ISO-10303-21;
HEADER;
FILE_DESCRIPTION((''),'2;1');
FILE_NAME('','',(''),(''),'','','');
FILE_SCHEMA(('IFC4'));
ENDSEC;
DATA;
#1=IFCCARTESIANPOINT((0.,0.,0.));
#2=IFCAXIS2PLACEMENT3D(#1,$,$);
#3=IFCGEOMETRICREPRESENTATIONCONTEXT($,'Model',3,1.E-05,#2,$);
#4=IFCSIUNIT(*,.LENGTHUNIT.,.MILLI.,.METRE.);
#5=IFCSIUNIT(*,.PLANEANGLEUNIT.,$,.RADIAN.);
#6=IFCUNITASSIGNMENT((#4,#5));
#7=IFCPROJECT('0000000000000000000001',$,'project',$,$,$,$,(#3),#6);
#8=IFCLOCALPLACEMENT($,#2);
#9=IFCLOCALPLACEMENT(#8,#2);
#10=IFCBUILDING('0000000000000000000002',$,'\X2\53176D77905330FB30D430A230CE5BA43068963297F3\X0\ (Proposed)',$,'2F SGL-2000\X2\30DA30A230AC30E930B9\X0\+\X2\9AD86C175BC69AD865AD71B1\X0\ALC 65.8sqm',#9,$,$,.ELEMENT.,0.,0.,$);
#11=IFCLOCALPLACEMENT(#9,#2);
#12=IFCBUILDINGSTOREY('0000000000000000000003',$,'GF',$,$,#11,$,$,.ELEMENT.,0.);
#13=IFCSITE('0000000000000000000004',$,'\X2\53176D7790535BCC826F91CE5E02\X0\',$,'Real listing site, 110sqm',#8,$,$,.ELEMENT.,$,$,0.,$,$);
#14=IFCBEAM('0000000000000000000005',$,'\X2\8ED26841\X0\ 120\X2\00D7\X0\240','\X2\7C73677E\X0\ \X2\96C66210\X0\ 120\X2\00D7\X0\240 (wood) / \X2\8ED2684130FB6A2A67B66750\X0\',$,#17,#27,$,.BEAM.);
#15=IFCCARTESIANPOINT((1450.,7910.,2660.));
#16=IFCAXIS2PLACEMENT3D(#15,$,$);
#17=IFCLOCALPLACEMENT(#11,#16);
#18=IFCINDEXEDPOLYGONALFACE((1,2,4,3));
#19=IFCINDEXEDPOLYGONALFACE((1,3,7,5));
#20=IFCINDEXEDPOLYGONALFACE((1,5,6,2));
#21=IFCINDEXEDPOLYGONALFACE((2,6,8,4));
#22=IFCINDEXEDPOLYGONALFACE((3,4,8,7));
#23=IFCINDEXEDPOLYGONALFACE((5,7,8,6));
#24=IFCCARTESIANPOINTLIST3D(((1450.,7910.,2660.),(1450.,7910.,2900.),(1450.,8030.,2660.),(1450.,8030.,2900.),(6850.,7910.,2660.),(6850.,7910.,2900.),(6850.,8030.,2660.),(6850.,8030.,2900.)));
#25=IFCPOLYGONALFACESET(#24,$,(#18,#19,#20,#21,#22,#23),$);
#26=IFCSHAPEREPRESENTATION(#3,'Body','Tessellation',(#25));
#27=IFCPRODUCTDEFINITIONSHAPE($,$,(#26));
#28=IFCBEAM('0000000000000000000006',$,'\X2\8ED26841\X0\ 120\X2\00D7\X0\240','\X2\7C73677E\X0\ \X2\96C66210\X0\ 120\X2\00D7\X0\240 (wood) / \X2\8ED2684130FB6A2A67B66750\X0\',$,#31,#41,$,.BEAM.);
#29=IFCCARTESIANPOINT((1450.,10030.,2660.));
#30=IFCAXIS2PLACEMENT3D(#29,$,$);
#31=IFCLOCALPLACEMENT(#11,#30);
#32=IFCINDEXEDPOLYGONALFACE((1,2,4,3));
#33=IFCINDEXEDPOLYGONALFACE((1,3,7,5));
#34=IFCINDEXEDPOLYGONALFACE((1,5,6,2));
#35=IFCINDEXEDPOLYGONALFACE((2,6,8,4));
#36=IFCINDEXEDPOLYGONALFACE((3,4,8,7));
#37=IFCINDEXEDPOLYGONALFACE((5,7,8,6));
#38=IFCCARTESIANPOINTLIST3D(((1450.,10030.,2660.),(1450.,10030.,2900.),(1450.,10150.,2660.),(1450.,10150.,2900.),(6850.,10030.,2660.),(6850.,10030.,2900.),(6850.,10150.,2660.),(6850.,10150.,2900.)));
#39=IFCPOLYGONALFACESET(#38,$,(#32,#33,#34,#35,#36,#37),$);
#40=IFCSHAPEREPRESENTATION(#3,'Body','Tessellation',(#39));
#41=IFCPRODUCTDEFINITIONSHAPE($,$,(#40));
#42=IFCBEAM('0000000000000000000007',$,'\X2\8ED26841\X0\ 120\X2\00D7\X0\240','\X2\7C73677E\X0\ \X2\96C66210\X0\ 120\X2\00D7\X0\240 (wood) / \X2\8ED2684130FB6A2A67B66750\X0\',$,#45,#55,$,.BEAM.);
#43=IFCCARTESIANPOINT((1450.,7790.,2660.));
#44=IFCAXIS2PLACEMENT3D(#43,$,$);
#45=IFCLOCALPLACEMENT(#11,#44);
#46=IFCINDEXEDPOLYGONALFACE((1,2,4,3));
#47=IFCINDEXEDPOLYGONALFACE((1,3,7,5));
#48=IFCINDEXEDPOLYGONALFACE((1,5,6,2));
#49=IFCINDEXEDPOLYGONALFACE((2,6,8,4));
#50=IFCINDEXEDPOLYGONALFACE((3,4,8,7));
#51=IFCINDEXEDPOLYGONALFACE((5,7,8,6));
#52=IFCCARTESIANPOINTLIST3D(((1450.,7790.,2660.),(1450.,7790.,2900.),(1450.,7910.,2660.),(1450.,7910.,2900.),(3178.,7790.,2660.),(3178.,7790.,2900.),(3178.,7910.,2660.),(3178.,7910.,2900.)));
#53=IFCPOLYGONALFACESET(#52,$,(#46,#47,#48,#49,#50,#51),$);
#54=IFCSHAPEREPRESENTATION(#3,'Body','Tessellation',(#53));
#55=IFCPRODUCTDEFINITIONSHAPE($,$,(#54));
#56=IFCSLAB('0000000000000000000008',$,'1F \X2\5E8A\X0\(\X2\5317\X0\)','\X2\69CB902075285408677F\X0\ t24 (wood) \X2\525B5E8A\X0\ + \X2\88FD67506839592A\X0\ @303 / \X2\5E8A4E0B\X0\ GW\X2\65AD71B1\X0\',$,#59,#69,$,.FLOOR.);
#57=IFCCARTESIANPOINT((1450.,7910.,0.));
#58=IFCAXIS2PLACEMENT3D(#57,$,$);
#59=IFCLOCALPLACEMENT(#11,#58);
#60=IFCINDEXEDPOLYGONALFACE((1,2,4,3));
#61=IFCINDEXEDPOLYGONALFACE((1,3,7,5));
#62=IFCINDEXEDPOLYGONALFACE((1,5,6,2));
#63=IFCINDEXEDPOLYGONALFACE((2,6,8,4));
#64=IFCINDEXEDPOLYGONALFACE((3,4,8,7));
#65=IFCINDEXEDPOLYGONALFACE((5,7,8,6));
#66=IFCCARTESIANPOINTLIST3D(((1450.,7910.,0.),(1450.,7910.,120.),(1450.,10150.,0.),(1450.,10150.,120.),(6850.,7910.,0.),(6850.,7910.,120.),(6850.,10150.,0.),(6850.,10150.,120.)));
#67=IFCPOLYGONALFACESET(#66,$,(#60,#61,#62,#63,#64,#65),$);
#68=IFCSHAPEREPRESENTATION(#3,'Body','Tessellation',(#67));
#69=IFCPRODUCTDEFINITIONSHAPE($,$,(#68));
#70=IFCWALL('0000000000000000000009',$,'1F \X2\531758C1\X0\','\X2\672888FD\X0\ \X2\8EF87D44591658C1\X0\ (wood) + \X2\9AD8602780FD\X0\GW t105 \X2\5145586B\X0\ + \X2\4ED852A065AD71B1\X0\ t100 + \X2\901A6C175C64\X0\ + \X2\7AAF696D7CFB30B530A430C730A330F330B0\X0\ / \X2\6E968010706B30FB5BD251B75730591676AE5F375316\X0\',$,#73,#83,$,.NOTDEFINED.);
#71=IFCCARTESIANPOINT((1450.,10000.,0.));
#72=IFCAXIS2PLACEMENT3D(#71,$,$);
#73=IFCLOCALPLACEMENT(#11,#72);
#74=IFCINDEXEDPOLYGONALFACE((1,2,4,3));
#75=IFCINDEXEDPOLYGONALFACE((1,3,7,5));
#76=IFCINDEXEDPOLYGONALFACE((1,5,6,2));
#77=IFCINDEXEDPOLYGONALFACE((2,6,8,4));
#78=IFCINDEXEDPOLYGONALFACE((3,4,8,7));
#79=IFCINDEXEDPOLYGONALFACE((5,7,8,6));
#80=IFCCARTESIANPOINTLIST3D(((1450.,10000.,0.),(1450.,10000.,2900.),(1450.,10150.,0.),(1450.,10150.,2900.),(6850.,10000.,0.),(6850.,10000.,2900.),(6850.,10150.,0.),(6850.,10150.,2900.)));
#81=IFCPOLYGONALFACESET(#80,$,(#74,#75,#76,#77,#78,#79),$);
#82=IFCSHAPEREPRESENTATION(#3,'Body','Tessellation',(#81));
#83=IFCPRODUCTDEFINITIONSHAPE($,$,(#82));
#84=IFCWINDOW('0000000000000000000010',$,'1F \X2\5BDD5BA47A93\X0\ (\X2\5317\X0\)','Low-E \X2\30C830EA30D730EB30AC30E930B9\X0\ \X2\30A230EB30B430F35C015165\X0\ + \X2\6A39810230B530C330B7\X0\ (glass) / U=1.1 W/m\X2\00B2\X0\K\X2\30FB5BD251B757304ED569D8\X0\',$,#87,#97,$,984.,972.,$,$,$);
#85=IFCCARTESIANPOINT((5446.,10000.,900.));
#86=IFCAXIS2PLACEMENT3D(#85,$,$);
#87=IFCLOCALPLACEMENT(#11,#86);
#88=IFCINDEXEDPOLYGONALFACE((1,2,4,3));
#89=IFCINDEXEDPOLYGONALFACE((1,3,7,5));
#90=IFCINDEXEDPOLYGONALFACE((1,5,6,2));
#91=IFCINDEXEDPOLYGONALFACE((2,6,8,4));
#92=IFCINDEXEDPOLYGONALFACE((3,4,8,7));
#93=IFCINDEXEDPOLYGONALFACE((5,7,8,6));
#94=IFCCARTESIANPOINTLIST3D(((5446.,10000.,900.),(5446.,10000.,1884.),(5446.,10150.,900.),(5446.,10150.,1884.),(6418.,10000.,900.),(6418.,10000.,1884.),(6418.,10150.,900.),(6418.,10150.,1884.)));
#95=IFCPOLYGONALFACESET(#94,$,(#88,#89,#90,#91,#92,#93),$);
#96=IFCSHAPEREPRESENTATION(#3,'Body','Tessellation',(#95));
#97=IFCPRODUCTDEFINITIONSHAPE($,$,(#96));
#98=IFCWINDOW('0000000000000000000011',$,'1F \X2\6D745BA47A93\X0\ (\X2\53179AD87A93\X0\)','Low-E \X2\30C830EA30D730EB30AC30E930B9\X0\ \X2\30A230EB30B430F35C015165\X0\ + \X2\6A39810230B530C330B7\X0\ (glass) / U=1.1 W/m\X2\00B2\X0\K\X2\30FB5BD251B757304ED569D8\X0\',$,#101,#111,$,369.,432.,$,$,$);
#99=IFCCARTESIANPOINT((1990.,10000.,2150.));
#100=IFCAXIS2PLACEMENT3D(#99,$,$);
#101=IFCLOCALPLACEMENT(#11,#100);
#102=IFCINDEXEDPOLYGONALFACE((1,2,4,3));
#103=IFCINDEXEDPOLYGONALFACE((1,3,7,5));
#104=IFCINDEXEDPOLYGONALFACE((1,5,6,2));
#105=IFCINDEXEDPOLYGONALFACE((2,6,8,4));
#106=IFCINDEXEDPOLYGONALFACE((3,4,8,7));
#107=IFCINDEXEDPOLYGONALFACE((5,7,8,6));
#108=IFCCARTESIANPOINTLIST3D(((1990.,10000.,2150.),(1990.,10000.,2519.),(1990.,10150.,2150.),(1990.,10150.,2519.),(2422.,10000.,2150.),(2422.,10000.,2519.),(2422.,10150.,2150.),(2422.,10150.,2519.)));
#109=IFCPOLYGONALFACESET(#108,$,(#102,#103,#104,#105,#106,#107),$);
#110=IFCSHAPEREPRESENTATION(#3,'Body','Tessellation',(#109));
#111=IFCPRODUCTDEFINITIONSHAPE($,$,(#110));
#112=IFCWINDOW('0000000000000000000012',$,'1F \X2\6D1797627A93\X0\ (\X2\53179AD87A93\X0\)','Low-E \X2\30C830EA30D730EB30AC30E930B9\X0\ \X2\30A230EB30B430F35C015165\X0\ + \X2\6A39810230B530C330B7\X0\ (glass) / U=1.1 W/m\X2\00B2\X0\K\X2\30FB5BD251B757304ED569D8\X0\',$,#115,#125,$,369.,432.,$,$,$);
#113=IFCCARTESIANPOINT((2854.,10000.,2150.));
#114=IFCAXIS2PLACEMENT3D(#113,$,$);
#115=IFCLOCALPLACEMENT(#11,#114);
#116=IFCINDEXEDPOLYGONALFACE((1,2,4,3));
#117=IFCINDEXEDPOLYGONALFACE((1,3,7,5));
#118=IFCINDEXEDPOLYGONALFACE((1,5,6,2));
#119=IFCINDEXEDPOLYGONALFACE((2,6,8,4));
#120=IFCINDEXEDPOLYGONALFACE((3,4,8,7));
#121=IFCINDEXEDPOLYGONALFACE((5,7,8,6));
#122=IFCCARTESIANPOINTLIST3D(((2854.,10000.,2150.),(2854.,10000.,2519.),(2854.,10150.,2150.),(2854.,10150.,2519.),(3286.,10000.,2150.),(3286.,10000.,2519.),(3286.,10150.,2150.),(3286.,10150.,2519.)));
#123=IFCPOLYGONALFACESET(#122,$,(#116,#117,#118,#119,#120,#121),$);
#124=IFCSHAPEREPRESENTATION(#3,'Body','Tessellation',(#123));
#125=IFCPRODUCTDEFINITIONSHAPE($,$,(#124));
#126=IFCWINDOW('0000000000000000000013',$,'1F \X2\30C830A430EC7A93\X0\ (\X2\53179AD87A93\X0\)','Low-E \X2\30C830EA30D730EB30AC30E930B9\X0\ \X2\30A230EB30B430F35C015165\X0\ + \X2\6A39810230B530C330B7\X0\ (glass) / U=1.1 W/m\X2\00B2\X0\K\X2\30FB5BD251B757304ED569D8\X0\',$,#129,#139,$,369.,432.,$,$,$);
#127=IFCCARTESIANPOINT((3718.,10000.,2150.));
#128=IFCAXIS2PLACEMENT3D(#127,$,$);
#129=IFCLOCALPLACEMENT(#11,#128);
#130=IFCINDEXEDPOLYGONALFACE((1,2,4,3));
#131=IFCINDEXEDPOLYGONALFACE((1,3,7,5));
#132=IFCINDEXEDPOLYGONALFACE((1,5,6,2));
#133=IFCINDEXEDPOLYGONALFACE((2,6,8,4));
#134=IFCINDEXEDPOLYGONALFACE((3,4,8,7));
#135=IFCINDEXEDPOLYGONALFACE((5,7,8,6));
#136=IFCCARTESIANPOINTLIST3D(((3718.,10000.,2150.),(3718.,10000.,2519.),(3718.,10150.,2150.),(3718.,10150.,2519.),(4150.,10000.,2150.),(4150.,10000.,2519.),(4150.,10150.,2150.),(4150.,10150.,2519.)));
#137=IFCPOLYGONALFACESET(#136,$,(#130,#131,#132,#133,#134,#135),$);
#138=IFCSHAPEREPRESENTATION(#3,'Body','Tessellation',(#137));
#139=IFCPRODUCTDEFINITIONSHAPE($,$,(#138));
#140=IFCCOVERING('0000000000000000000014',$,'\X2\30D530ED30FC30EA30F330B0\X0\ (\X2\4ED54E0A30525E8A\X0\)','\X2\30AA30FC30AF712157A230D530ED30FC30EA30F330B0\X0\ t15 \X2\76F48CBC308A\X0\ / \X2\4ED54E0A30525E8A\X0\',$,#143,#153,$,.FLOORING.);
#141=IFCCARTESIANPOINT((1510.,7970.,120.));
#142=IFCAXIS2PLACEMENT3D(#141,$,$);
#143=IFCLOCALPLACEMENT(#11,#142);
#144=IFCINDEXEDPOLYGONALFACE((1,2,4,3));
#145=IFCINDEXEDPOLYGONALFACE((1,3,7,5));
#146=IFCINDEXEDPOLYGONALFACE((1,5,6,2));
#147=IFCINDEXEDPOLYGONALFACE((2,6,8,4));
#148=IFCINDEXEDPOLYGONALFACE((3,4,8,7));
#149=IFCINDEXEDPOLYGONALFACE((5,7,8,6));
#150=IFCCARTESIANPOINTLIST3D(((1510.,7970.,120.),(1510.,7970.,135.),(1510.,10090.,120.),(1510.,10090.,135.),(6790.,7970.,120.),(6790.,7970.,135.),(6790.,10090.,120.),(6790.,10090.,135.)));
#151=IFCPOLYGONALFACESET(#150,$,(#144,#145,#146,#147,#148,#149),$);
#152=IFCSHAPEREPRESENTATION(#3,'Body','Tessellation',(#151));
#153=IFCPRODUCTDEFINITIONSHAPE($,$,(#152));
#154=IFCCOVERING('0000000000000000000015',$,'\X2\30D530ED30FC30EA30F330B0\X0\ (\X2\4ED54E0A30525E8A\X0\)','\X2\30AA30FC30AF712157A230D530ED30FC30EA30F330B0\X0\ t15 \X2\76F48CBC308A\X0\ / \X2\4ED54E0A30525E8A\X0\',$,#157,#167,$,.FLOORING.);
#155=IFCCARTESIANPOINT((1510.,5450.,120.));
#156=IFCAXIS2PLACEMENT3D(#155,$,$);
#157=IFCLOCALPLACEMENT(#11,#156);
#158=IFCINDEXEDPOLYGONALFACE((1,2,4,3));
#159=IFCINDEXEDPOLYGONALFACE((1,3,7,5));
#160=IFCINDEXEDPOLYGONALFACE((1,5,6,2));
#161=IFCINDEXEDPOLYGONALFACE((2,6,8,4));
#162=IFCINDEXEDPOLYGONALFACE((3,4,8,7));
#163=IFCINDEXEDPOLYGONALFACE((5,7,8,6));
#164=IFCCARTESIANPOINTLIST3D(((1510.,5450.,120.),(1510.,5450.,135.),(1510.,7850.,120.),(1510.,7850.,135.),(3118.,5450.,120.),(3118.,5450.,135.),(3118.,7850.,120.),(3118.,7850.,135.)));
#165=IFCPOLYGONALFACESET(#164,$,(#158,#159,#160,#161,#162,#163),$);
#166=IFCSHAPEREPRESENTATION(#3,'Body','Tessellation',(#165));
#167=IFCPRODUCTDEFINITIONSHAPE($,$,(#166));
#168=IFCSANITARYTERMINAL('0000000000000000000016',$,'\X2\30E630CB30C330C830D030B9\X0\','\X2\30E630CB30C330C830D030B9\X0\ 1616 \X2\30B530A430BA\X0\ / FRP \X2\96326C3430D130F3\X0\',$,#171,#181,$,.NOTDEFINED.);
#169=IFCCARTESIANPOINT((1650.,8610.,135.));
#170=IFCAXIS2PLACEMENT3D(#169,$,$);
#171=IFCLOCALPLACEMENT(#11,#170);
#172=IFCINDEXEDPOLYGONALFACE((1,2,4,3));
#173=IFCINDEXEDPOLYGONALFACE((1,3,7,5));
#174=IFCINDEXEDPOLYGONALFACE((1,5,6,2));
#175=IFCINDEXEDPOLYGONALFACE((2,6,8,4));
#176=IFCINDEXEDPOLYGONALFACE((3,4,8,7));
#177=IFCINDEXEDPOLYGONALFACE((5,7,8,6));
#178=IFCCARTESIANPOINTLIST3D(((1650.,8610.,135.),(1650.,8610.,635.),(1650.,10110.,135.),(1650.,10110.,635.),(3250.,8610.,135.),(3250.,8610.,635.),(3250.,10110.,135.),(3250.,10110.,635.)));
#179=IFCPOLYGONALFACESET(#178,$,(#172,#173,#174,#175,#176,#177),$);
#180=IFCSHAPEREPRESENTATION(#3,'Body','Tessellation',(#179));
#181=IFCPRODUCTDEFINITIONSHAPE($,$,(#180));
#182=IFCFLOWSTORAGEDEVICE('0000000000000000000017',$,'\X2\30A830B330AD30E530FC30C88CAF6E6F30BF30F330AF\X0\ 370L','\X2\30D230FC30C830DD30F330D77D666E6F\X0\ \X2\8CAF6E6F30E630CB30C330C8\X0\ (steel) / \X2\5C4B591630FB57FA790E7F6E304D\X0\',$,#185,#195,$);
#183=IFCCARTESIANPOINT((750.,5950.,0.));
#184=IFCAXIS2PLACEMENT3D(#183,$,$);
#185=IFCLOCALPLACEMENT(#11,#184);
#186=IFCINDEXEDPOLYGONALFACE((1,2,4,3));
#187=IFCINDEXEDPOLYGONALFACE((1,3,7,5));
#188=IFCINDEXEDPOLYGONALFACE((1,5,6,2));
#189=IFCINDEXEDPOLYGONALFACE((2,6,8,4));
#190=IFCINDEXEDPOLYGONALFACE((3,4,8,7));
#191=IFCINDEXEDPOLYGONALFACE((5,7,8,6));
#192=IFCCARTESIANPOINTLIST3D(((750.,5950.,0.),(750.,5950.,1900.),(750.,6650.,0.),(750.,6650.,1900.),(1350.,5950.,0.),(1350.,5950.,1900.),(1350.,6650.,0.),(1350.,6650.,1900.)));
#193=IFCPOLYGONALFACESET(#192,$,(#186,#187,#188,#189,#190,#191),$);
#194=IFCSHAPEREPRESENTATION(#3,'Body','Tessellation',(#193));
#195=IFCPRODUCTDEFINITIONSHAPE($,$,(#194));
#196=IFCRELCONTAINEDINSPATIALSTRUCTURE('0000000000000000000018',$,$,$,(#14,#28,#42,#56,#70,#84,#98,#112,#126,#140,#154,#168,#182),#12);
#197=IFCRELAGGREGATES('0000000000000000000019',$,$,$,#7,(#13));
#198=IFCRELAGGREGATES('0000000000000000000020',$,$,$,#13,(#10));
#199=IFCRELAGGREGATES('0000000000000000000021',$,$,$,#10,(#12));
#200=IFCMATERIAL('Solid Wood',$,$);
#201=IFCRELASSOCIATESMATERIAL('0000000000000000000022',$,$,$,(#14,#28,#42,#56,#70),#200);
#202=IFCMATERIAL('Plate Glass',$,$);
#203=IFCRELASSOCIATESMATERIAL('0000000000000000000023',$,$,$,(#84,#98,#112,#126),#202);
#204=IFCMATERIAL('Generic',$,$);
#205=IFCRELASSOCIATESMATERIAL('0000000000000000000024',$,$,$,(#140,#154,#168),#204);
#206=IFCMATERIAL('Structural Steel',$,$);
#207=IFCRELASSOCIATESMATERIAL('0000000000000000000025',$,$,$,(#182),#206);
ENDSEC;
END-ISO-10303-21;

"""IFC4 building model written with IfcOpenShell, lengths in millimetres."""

from ifc_helpers import new_model, si_unit, frame, frame_2d, origin, place, context, project, spatial, rectangle, extrude, material, element, fill, save


model = new_model("IFC4")

# Units and contexts
model_context = context("Model", 3, precision=1e-05, world=origin())
ifc_project = project(units=[si_unit("LENGTHUNIT", "METRE", prefix="MILLI"), si_unit("PLANEANGLEUNIT", "RADIAN")], contexts=[model_context])

# Site, building, storey
site_placement = place(None, origin())
site = spatial("IfcSite", under=ifc_project, at=site_placement, Name="北海道富良野市", ObjectType="Real listing site, 110sqm", CompositionType="ELEMENT", RefElevation=0.0)
building_placement = place(site_placement, origin())
building = spatial("IfcBuilding", under=site, at=building_placement, Name="北海道・ピアノ室と防音 (Proposed)", ObjectType="2F SGL-2000ペアガラス+高気密高断熱ALC 65.8sqm", CompositionType="ELEMENT", ElevationOfRefHeight=0.0, ElevationOfTerrain=0.0)
storey_placement = place(building_placement, origin())
storey = spatial("IfcBuildingStorey", under=building, at=storey_placement, Name="GF", CompositionType="ELEMENT", Elevation=0.0)

# Shared definitions
ifc_material_1 = material(Name="Solid Wood")

# Beams
beam_1_placement = place(storey_placement, frame((1450.0, 7910.0, 2660.0)))
element("IfcBeam", 1, at=beam_1_placement, inside=storey, material=ifc_material_1, Name="軒桁 120×240", Description="米松 集成 120×240 (wood) / 軒桁・横架材", PredefinedType="BEAM", context=model_context, shape_type="SweptSolid", body=[
    extrude(rectangle(XDim=5400.0, YDim=120.0, at=frame_2d((2700.0, 60.0))), frame((1450.0, 7910.0, 2660.0)), (0.0, 0.0, 1.0), 240.0),
])
beam_2_placement = place(storey_placement, frame((1450.0, 10030.0, 2660.0)))
element("IfcBeam", 2, at=beam_2_placement, inside=storey, material=ifc_material_1, Name="軒桁 120×240", Description="米松 集成 120×240 (wood) / 軒桁・横架材", PredefinedType="BEAM", context=model_context, shape_type="SweptSolid", body=[
    extrude(rectangle(XDim=5400.0, YDim=120.0, at=frame_2d((2700.0, 60.0))), frame((1450.0, 10030.0, 2660.0)), (0.0, 0.0, 1.0), 240.0),
])
beam_3_placement = place(storey_placement, frame((1450.0, 7790.0, 2660.0)))
element("IfcBeam", 3, at=beam_3_placement, inside=storey, material=ifc_material_1, Name="軒桁 120×240", Description="米松 集成 120×240 (wood) / 軒桁・横架材", PredefinedType="BEAM", context=model_context, shape_type="SweptSolid", body=[
    extrude(rectangle(XDim=1728.0, YDim=120.0, at=frame_2d((864.0, 60.0))), frame((1450.0, 7790.0, 2660.0)), (0.0, 0.0, 1.0), 240.0),
])

# Slab
slab_placement = place(storey_placement, frame((1450.0, 7910.0, 0.0)))
element("IfcSlab", 4, at=slab_placement, inside=storey, material=ifc_material_1, Name="1F 床(北)", Description="構造用合板 t24 (wood) 剛床 + 製材根太 @303 / 床下 GW断熱", PredefinedType="FLOOR", context=model_context, shape_type="SweptSolid", body=[
    extrude(rectangle(XDim=5400.0, YDim=2240.0, at=frame_2d((2700.0, 1120.0))), frame((1450.0, 7910.0, 0.0)), (0.0, 0.0, 1.0), 120.0),
])

# Wall, openings, windows
wall_1_placement = place(storey_placement, frame((1450.0, 10000.0, 0.0)))
wall_1 = element("IfcWall", 5, at=wall_1_placement, inside=storey, material=ifc_material_1, Name="1F 北壁", Description="木製 軸組外壁 (wood) + 高性能GW t105 充填 + 付加断熱 t100 + 通気層 + 窯業系サイディング / 準耐火・寒冷地外皮強化", PredefinedType="NOTDEFINED", context=model_context, shape_type="SweptSolid", body=[
    extrude(rectangle(XDim=5400.0, YDim=150.0, at=frame_2d((2700.0, 75.0))), frame((1450.0, 10000.0, 0.0)), (0.0, 0.0, 1.0), 2900.0),
])
opening_1_placement = place(storey_placement, frame((5446.0, 10000.0, 900.0)))
opening_1 = element("IfcOpeningElement", 6, at=opening_1_placement, cuts=wall_1, PredefinedType="NOTDEFINED", context=model_context, shape_type="SweptSolid", body=[
    extrude(rectangle(XDim=972.0, YDim=150.0, at=frame_2d((486.0, 75.0))), frame((5446.0, 10000.0, 900.0)), (0.0, 0.0, 1.0), 984.0),
])
opening_2_placement = place(storey_placement, frame((1990.0, 10000.0, 2150.0)))
opening_2 = element("IfcOpeningElement", 7, at=opening_2_placement, cuts=wall_1, PredefinedType="NOTDEFINED", context=model_context, shape_type="SweptSolid", body=[
    extrude(rectangle(XDim=432.0, YDim=150.0, at=frame_2d((216.0, 75.0))), frame((1990.0, 10000.0, 2150.0)), (0.0, 0.0, 1.0), 369.0),
])
opening_3_placement = place(storey_placement, frame((2854.0, 10000.0, 2150.0)))
opening_3 = element("IfcOpeningElement", 8, at=opening_3_placement, cuts=wall_1, PredefinedType="NOTDEFINED", context=model_context, shape_type="SweptSolid", body=[
    extrude(rectangle(XDim=432.0, YDim=150.0, at=frame_2d((216.0, 75.0))), frame((2854.0, 10000.0, 2150.0)), (0.0, 0.0, 1.0), 369.0),
])
opening_4_placement = place(storey_placement, frame((3718.0, 10000.0, 2150.0)))
opening_4 = element("IfcOpeningElement", 9, at=opening_4_placement, cuts=wall_1, PredefinedType="NOTDEFINED", context=model_context, shape_type="SweptSolid", body=[
    extrude(rectangle(XDim=432.0, YDim=150.0, at=frame_2d((216.0, 75.0))), frame((3718.0, 10000.0, 2150.0)), (0.0, 0.0, 1.0), 369.0),
])
ifc_material_2 = material(Name="Plate Glass")
window_1_placement = place(storey_placement, frame((5446.0, 10000.0, 900.0)))
window_1 = element("IfcWindow", 10, at=window_1_placement, inside=storey, material=ifc_material_2, Name="1F 寝室窓 (北)", Description="Low-E トリプルガラス アルゴン封入 + 樹脂サッシ (glass) / U=1.1 W/m²K・寒冷地仕様", OverallHeight=984.0, OverallWidth=972.0, context=model_context, shape_type="SweptSolid", body=[
    extrude(rectangle(XDim=972.0, YDim=150.0, at=frame_2d((486.0, 75.0))), frame((5446.0, 10000.0, 900.0)), (0.0, 0.0, 1.0), 984.0),
])
fill(opening_1, window_1)
window_2_placement = place(storey_placement, frame((1990.0, 10000.0, 2150.0)))
window_2 = element("IfcWindow", 11, at=window_2_placement, inside=storey, material=ifc_material_2, Name="1F 浴室窓 (北高窓)", Description="Low-E トリプルガラス アルゴン封入 + 樹脂サッシ (glass) / U=1.1 W/m²K・寒冷地仕様", OverallHeight=369.0, OverallWidth=432.0, context=model_context, shape_type="SweptSolid", body=[
    extrude(rectangle(XDim=432.0, YDim=150.0, at=frame_2d((216.0, 75.0))), frame((1990.0, 10000.0, 2150.0)), (0.0, 0.0, 1.0), 369.0),
])
fill(opening_2, window_2)
window_3_placement = place(storey_placement, frame((2854.0, 10000.0, 2150.0)))
window_3 = element("IfcWindow", 12, at=window_3_placement, inside=storey, material=ifc_material_2, Name="1F 洗面窓 (北高窓)", Description="Low-E トリプルガラス アルゴン封入 + 樹脂サッシ (glass) / U=1.1 W/m²K・寒冷地仕様", OverallHeight=369.0, OverallWidth=432.0, context=model_context, shape_type="SweptSolid", body=[
    extrude(rectangle(XDim=432.0, YDim=150.0, at=frame_2d((216.0, 75.0))), frame((2854.0, 10000.0, 2150.0)), (0.0, 0.0, 1.0), 369.0),
])
fill(opening_3, window_3)
window_4_placement = place(storey_placement, frame((3718.0, 10000.0, 2150.0)))
window_4 = element("IfcWindow", 13, at=window_4_placement, inside=storey, material=ifc_material_2, Name="1F トイレ窓 (北高窓)", Description="Low-E トリプルガラス アルゴン封入 + 樹脂サッシ (glass) / U=1.1 W/m²K・寒冷地仕様", OverallHeight=369.0, OverallWidth=432.0, context=model_context, shape_type="SweptSolid", body=[
    extrude(rectangle(XDim=432.0, YDim=150.0, at=frame_2d((216.0, 75.0))), frame((3718.0, 10000.0, 2150.0)), (0.0, 0.0, 1.0), 369.0),
])
fill(opening_4, window_4)

# Coverings
ifc_material_3 = material(Name="Generic")
covering_1_placement = place(storey_placement, frame((1510.0, 7970.0, 120.0)))
element("IfcCovering", 14, at=covering_1_placement, inside=storey, material=ifc_material_3, Name="フローリング (仕上げ床)", Description="オーク無垢フローリング t15 直貼り / 仕上げ床", PredefinedType="FLOORING", context=model_context, shape_type="SweptSolid", body=[
    extrude(rectangle(XDim=5280.0, YDim=2120.0, at=frame_2d((2640.0, 1060.0))), frame((1510.0, 7970.0, 120.0)), (0.0, 0.0, 1.0), 15.0),
])
covering_2_placement = place(storey_placement, frame((1510.0, 5450.0, 120.0)))
element("IfcCovering", 15, at=covering_2_placement, inside=storey, material=ifc_material_3, Name="フローリング (仕上げ床)", Description="オーク無垢フローリング t15 直貼り / 仕上げ床", PredefinedType="FLOORING", context=model_context, shape_type="SweptSolid", body=[
    extrude(rectangle(XDim=1608.0, YDim=2400.0, at=frame_2d((804.0, 1200.0))), frame((1510.0, 5450.0, 120.0)), (0.0, 0.0, 1.0), 15.0),
])

# Sanitary terminal
sanitary_terminal_placement = place(storey_placement, frame((1650.0, 8610.0, 135.0)))
element("IfcSanitaryTerminal", 16, at=sanitary_terminal_placement, inside=storey, material=ifc_material_3, Name="ユニットバス", Description="ユニットバス 1616 サイズ / FRP 防水パン", PredefinedType="NOTDEFINED", context=model_context, shape_type="SweptSolid", body=[
    extrude(rectangle(XDim=1600.0, YDim=1500.0, at=frame_2d((800.0, 750.0))), frame((1650.0, 8610.0, 135.0)), (0.0, 0.0, 1.0), 500.0),
])

# Flow storage device
ifc_material_4 = material(Name="Structural Steel")
flow_storage_device_placement = place(storey_placement, frame((750.0, 5950.0, 0.0)))
element("IfcFlowStorageDevice", 17, at=flow_storage_device_placement, inside=storey, material=ifc_material_4, Name="エコキュート貯湯タンク 370L", Description="ヒートポンプ給湯 貯湯ユニット (steel) / 屋外・基礎置き", context=model_context, shape_type="SweptSolid", body=[
    extrude(rectangle(XDim=600.0, YDim=700.0, at=frame_2d((300.0, 350.0))), frame((750.0, 5950.0, 0.0)), (0.0, 0.0, 1.0), 1900.0),
])

save(model, "model.ifc")
